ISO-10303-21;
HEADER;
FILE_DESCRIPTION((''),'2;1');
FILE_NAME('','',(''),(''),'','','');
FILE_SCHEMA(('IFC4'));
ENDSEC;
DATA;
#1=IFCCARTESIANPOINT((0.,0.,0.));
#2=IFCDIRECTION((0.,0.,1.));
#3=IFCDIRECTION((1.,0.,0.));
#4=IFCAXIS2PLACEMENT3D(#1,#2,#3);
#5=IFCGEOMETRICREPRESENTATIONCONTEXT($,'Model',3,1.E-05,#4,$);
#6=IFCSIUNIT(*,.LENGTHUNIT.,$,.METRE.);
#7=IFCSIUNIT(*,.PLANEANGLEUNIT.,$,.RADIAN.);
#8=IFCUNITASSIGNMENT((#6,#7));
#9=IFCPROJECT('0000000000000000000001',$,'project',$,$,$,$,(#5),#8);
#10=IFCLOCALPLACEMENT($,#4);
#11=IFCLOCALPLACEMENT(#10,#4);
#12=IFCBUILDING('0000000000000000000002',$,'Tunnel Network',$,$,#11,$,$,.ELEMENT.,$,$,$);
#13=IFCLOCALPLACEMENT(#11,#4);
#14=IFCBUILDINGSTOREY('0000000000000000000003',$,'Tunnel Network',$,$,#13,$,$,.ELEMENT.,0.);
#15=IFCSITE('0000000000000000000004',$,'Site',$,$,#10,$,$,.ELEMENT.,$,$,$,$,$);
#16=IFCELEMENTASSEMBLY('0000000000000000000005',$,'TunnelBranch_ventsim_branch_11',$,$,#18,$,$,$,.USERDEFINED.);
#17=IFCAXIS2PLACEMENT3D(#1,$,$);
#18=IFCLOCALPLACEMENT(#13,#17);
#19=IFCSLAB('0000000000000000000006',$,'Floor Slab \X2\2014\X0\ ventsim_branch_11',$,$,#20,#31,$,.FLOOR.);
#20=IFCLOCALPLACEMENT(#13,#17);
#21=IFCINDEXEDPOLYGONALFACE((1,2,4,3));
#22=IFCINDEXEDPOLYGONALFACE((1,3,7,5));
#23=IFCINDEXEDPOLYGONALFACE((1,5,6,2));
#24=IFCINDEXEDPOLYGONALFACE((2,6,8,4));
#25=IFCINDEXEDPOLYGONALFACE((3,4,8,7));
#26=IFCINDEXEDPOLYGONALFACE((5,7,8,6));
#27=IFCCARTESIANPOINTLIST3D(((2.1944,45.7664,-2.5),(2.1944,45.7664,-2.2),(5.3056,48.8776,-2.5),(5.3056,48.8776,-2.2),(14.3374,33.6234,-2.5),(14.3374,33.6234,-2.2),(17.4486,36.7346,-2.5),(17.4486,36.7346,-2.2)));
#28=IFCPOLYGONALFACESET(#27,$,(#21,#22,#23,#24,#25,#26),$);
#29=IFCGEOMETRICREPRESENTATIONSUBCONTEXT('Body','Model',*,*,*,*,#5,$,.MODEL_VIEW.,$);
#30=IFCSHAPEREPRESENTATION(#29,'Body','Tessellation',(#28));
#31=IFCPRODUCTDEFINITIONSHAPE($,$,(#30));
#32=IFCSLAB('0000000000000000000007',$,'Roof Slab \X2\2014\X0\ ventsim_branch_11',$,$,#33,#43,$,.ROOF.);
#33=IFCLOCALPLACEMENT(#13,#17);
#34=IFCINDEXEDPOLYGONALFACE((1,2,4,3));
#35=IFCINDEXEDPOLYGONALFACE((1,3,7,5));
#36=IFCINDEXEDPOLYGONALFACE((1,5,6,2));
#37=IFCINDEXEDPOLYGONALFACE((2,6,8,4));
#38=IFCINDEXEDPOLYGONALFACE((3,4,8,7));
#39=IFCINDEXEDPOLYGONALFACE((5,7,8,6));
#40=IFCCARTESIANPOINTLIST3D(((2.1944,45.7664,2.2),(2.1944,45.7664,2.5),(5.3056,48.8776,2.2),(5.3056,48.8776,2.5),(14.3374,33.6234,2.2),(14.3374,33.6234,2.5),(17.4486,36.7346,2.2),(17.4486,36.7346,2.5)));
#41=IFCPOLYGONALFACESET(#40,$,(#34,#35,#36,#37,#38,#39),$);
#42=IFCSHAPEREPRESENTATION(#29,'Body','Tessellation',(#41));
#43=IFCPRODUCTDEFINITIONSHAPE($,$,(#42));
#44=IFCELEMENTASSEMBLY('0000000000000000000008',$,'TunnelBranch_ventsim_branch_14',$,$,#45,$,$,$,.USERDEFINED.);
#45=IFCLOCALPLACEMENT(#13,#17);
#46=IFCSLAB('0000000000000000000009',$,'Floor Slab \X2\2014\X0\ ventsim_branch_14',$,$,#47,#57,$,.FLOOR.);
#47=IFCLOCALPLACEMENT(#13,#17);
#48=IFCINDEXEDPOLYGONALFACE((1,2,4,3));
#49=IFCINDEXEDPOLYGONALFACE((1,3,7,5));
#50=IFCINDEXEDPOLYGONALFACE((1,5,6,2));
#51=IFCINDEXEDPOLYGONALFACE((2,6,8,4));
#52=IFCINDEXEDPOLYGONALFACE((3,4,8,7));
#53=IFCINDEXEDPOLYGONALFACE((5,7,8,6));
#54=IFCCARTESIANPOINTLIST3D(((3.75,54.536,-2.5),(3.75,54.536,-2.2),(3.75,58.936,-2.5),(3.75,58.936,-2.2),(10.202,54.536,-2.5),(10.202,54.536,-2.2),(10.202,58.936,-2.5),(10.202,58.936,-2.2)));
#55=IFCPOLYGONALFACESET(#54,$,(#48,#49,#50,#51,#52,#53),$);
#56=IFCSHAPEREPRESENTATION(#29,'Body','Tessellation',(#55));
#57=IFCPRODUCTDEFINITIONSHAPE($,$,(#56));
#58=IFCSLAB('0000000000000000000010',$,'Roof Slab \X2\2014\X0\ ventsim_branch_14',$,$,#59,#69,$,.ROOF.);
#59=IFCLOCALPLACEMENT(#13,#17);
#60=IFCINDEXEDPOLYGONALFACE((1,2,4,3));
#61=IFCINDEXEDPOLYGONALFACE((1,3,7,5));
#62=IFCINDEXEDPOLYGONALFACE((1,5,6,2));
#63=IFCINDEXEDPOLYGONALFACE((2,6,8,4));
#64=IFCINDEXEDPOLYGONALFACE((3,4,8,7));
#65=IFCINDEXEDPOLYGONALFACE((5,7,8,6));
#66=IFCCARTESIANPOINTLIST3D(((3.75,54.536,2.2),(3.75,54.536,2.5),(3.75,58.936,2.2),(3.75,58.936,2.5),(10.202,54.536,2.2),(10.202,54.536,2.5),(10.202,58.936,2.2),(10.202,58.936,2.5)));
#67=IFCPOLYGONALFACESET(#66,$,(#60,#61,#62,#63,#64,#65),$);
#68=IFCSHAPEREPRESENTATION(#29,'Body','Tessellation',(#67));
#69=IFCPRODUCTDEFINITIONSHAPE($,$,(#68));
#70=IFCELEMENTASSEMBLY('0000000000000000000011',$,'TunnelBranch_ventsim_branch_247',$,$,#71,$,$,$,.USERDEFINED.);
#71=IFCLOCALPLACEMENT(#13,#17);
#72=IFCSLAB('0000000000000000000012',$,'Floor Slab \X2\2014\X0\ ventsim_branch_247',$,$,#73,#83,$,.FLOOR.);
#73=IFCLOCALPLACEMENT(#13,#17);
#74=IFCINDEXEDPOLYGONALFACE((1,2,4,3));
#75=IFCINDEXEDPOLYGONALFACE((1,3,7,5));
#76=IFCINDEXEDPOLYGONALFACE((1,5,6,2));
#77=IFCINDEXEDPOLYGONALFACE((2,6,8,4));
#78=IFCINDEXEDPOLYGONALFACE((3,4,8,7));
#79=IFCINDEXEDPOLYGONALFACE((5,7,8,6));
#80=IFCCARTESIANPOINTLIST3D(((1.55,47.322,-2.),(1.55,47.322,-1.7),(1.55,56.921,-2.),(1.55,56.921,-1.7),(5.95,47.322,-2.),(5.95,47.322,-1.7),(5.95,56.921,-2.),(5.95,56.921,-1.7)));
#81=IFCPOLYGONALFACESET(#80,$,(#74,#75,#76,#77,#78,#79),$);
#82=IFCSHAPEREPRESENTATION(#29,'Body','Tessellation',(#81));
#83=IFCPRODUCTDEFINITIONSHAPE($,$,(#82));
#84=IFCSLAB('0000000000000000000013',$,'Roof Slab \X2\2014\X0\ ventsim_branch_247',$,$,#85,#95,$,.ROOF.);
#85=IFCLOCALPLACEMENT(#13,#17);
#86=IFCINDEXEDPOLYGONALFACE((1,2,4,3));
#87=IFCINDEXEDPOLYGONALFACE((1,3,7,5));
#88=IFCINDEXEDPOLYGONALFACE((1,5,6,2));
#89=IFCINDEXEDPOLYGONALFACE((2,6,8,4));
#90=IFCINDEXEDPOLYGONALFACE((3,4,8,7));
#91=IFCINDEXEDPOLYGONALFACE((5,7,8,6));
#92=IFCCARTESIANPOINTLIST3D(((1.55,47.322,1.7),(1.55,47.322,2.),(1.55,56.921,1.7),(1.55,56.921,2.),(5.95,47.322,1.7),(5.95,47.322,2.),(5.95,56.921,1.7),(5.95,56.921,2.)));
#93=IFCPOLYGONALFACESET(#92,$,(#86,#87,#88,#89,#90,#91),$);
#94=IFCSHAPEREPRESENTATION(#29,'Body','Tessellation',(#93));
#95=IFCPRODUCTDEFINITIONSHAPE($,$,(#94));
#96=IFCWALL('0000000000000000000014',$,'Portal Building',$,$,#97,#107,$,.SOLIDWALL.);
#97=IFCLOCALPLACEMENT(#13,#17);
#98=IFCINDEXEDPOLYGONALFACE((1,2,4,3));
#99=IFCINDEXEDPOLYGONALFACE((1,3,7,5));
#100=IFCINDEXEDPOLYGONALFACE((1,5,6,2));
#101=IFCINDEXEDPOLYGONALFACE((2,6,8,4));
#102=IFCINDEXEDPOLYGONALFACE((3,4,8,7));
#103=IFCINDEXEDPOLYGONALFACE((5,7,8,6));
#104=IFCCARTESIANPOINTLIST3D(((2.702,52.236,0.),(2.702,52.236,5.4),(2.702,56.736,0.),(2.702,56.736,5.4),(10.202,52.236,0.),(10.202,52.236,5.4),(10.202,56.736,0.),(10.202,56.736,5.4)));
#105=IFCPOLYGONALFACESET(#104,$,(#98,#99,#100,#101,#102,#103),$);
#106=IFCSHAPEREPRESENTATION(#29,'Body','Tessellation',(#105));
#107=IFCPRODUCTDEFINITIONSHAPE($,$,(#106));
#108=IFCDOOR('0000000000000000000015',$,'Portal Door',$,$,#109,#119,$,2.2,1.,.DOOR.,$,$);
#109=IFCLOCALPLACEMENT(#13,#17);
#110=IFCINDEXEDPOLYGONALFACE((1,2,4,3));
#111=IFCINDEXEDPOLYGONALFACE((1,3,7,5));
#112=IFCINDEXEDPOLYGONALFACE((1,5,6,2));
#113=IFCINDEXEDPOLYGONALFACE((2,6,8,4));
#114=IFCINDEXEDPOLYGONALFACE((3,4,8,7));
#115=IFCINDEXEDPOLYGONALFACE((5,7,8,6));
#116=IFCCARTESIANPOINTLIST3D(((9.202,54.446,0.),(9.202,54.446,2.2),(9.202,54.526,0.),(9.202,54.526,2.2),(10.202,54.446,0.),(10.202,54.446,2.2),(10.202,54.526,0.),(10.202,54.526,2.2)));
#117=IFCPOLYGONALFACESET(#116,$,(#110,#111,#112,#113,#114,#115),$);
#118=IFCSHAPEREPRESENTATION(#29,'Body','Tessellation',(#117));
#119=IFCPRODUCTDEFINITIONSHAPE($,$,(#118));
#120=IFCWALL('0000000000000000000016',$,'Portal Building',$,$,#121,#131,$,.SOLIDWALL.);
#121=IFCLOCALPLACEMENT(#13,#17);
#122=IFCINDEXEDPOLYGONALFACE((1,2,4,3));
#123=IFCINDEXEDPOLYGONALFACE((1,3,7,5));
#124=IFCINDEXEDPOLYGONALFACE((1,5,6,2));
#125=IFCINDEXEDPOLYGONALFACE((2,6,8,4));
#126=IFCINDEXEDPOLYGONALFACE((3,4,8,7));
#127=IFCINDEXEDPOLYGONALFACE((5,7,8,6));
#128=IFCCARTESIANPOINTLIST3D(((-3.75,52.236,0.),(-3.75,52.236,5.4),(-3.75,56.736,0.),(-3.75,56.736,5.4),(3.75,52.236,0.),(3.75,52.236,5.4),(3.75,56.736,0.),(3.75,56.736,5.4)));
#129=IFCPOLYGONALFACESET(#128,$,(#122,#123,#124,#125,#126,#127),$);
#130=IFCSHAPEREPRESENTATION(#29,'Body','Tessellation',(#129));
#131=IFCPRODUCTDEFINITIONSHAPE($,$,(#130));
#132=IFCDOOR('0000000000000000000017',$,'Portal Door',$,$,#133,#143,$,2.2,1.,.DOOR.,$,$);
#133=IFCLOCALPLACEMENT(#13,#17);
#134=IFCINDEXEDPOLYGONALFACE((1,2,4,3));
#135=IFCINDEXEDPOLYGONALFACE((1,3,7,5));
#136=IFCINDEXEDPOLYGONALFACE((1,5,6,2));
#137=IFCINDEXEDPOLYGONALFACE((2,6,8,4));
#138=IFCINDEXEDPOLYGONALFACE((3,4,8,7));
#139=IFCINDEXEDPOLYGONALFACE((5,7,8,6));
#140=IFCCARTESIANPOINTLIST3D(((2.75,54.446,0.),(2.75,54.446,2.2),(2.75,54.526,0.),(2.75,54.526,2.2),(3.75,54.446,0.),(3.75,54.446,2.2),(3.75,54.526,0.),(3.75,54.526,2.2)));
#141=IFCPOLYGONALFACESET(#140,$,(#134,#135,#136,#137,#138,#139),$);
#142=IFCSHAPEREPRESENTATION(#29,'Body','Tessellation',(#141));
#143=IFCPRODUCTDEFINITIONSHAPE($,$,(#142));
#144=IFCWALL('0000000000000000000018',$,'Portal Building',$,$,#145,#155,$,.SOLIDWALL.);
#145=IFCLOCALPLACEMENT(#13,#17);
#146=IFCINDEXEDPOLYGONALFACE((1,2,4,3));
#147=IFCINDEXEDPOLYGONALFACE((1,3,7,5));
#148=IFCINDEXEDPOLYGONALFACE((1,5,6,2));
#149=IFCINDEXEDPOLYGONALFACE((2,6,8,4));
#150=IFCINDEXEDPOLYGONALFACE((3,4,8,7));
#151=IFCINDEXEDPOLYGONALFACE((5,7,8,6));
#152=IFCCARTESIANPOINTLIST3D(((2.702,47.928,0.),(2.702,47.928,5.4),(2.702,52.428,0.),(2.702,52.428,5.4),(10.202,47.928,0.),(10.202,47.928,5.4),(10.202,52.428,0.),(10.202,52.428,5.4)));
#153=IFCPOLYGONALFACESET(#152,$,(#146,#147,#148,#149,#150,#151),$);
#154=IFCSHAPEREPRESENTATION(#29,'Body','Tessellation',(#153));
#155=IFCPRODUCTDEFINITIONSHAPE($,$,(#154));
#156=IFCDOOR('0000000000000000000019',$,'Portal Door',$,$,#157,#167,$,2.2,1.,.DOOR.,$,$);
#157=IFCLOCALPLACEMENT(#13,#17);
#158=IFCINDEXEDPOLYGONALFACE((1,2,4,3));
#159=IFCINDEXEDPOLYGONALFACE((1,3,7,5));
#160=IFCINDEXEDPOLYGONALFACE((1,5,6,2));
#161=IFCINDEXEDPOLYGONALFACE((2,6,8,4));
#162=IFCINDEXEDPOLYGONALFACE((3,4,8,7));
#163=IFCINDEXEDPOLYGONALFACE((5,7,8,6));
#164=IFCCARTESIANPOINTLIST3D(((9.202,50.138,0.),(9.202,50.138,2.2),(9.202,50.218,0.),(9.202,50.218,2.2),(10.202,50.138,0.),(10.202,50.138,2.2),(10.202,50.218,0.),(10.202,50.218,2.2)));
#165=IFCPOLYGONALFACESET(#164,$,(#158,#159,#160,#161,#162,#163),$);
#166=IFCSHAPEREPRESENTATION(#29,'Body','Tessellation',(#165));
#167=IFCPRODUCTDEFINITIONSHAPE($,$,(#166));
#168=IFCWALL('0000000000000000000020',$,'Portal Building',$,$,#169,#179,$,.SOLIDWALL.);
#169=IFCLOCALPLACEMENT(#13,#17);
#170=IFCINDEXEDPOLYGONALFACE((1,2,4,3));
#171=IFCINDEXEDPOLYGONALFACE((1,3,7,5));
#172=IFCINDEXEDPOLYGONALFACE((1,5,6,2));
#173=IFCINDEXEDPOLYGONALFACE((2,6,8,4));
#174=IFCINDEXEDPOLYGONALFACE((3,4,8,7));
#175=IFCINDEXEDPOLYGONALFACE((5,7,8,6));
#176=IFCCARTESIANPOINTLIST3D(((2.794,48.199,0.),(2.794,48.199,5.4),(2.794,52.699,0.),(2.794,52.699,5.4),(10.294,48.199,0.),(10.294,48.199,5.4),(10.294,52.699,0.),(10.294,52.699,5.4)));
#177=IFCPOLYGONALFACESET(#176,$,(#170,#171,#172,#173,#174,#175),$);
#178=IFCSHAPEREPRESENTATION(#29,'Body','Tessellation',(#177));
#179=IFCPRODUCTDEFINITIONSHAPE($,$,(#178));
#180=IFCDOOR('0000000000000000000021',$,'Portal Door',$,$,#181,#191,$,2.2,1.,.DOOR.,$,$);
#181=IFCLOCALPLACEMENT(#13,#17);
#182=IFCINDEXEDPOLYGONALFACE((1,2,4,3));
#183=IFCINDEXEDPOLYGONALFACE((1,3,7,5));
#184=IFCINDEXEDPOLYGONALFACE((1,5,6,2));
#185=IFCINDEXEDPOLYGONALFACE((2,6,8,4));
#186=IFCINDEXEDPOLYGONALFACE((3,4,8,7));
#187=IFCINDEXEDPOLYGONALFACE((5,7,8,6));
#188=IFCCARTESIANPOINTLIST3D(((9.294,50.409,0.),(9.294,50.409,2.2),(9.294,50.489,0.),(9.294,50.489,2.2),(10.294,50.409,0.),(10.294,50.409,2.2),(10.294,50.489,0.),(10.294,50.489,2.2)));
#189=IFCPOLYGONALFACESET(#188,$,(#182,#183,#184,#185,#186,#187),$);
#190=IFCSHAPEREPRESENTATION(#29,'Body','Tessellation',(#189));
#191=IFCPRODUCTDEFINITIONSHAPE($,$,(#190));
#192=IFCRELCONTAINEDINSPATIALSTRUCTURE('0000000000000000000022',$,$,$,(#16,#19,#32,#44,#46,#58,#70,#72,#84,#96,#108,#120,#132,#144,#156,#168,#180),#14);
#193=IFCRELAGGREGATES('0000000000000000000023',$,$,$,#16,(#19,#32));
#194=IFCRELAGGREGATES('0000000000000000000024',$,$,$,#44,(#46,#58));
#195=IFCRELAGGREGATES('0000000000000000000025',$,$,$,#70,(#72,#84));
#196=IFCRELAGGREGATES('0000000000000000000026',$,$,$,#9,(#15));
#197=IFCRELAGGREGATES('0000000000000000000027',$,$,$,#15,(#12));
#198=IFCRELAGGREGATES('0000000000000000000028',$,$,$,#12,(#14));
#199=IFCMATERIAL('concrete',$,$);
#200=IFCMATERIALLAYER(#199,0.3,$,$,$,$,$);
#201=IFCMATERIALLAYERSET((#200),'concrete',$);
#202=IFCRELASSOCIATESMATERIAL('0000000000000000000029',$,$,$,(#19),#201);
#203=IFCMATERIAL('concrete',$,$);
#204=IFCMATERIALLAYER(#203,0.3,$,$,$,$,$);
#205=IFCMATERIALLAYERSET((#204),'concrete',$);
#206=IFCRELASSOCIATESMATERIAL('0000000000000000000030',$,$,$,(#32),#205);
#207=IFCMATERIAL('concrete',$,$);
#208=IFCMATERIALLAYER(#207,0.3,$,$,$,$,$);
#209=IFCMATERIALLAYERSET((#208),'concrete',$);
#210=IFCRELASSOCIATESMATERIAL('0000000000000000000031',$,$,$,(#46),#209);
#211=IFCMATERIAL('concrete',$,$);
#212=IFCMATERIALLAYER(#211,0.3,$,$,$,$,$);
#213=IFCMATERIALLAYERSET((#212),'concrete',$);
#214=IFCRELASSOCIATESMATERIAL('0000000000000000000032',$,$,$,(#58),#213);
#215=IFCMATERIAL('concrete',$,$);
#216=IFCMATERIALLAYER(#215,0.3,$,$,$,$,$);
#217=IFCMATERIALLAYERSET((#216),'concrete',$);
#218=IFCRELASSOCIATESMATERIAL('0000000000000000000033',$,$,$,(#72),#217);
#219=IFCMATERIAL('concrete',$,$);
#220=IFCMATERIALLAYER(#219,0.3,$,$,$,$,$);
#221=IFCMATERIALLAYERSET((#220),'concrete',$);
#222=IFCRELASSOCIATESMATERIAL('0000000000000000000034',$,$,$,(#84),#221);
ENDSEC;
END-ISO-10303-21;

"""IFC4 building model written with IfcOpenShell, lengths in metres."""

from ifc_helpers import new_model, si_unit, frame, origin_with_axes, origin_2d_with_axis, place, context, subcontext, project, spatial, rectangle, extrude, material, layer, layer_set, layer_usage, element, aggregate, save


model = new_model("IFC4")

# Units and contexts
model_context = context("Model", 3, precision=1e-05, world=origin_with_axes())
body_context = subcontext(model_context, "Body", "Model", "MODEL_VIEW")
ifc_project = project(units=[si_unit("LENGTHUNIT", "METRE"), si_unit("PLANEANGLEUNIT", "RADIAN")], contexts=[model_context])

# Site, building, storey
site_placement = place(None, origin_with_axes())
site = spatial("IfcSite", under=ifc_project, at=site_placement, Name="Site", CompositionType="ELEMENT")
building_placement = place(site_placement, origin_with_axes())
building = spatial("IfcBuilding", under=site, at=building_placement, Name="Tunnel Network", CompositionType="ELEMENT")
storey_placement = place(building_placement, origin_with_axes())
storey = spatial("IfcBuildingStorey", under=building, at=storey_placement, Name="Tunnel Network", CompositionType="ELEMENT", Elevation=0.0)

# Element assemblies, slabs
assembly_1_placement = place(storey_placement, frame((5.4117, 48.9837, 0.0), z_axis=(0.707107, -0.707107, 0.0), x_axis=(-0.707107, -0.707107, 0.0)))
assembly_1 = element("IfcElementAssembly", 1, at=assembly_1_placement, inside=storey, Name="TunnelBranch_ventsim_branch_11", PredefinedType="USERDEFINED")
ifc_material_1 = material(Name="concrete")
ifc_layer_1 = layer(ifc_material_1, 0.3)
ifc_layer_set_1 = layer_set([ifc_layer_1], Name="concrete")
ifc_layer_usage_1 = layer_usage(ifc_layer_set_1, "AXIS3", "POSITIVE", 0.0)
slab_1_placement = place(storey_placement, frame((3.75, 47.322, -2.35), z_axis=(0.707107, -0.707107, 0.0), x_axis=(-0.707107, -0.707107, 0.0)))
slab_1 = element("IfcSlab", 2, at=slab_1_placement, inside=storey, material=ifc_layer_usage_1, Name="Floor Slab — ventsim_branch_11", PredefinedType="FLOOR", context=body_context, shape_type="SweptSolid", body=[
    extrude(rectangle(XDim=4.4, YDim=0.3, at=origin_2d_with_axis()), origin_with_axes(), (0.0, 0.0, 1.0), 17.1728),
])
ifc_material_2 = material(Name="concrete")
ifc_layer_2 = layer(ifc_material_2, 0.3)
ifc_layer_set_2 = layer_set([ifc_layer_2], Name="concrete")
ifc_layer_usage_2 = layer_usage(ifc_layer_set_2, "AXIS3", "POSITIVE", 0.0)
slab_2_placement = place(storey_placement, frame((3.75, 47.322, 2.35), z_axis=(0.707107, -0.707107, 0.0), x_axis=(-0.707107, -0.707107, 0.0)))
slab_2 = element("IfcSlab", 3, at=slab_2_placement, inside=storey, material=ifc_layer_usage_2, Name="Roof Slab — ventsim_branch_11", PredefinedType="ROOF", context=body_context, shape_type="SweptSolid", body=[
    extrude(rectangle(XDim=4.4, YDim=0.3, at=origin_2d_with_axis()), origin_with_axes(), (0.0, 0.0, 1.0), 17.1728),
])
assembly_2_placement = place(storey_placement, frame((10.202, 54.386, 0.0), z_axis=(-1.0, 0.0, 0.0), x_axis=(0.0, 1.0, 0.0)))
assembly_2 = element("IfcElementAssembly", 4, at=assembly_2_placement, inside=storey, Name="TunnelBranch_ventsim_branch_14", PredefinedType="USERDEFINED")
ifc_material_3 = material(Name="concrete")
ifc_layer_3 = layer(ifc_material_3, 0.3)
ifc_layer_set_3 = layer_set([ifc_layer_3], Name="concrete")
ifc_layer_usage_3 = layer_usage(ifc_layer_set_3, "AXIS3", "POSITIVE", 0.0)
slab_3_placement = place(storey_placement, frame((10.202, 56.736, -2.35), z_axis=(-1.0, 0.0, 0.0), x_axis=(0.0, 1.0, 0.0)))
slab_3 = element("IfcSlab", 5, at=slab_3_placement, inside=storey, material=ifc_layer_usage_3, Name="Floor Slab — ventsim_branch_14", PredefinedType="FLOOR", context=body_context, shape_type="SweptSolid", body=[
    extrude(rectangle(XDim=4.4, YDim=0.3, at=origin_2d_with_axis()), origin_with_axes(), (0.0, 0.0, 1.0), 6.452),
])
ifc_material_4 = material(Name="concrete")
ifc_layer_4 = layer(ifc_material_4, 0.3)
ifc_layer_set_4 = layer_set([ifc_layer_4], Name="concrete")
ifc_layer_usage_4 = layer_usage(ifc_layer_set_4, "AXIS3", "POSITIVE", 0.0)
slab_4_placement = place(storey_placement, frame((10.202, 56.736, 2.35), z_axis=(-1.0, 0.0, 0.0), x_axis=(0.0, 1.0, 0.0)))
slab_4 = element("IfcSlab", 6, at=slab_4_placement, inside=storey, material=ifc_layer_usage_4, Name="Roof Slab — ventsim_branch_14", PredefinedType="ROOF", context=body_context, shape_type="SweptSolid", body=[
    extrude(rectangle(XDim=4.4, YDim=0.3, at=origin_2d_with_axis()), origin_with_axes(), (0.0, 0.0, 1.0), 6.452),
])
assembly_3_placement = place(storey_placement, frame((1.4, 47.322, 0.0), z_axis=(0.0, 1.0, 0.0), x_axis=(1.0, 0.0, 0.0)))
assembly_3 = element("IfcElementAssembly", 7, at=assembly_3_placement, inside=storey, Name="TunnelBranch_ventsim_branch_247", PredefinedType="USERDEFINED")
ifc_material_5 = material(Name="concrete")
ifc_layer_5 = layer(ifc_material_5, 0.3)
ifc_layer_set_5 = layer_set([ifc_layer_5], Name="concrete")
ifc_layer_usage_5 = layer_usage(ifc_layer_set_5, "AXIS3", "POSITIVE", 0.0)
slab_5_placement = place(storey_placement, frame((3.75, 47.322, -1.85), z_axis=(0.0, 1.0, 0.0), x_axis=(1.0, 0.0, 0.0)))
slab_5 = element("IfcSlab", 8, at=slab_5_placement, inside=storey, material=ifc_layer_usage_5, Name="Floor Slab — ventsim_branch_247", PredefinedType="FLOOR", context=body_context, shape_type="SweptSolid", body=[
    extrude(rectangle(XDim=4.4, YDim=0.3, at=origin_2d_with_axis()), origin_with_axes(), (0.0, 0.0, 1.0), 9.599),
])
ifc_material_6 = material(Name="concrete")
ifc_layer_6 = layer(ifc_material_6, 0.3)
ifc_layer_set_6 = layer_set([ifc_layer_6], Name="concrete")
ifc_layer_usage_6 = layer_usage(ifc_layer_set_6, "AXIS3", "POSITIVE", 0.0)
slab_6_placement = place(storey_placement, frame((3.75, 47.322, 1.85), z_axis=(0.0, 1.0, 0.0), x_axis=(1.0, 0.0, 0.0)))
slab_6 = element("IfcSlab", 9, at=slab_6_placement, inside=storey, material=ifc_layer_usage_6, Name="Roof Slab — ventsim_branch_247", PredefinedType="ROOF", context=body_context, shape_type="SweptSolid", body=[
    extrude(rectangle(XDim=4.4, YDim=0.3, at=origin_2d_with_axis()), origin_with_axes(), (0.0, 0.0, 1.0), 9.599),
])

# Wall
wall_1_placement = place(storey_placement, frame((6.452, 54.486, 0.0), z_axis=(0.0, 0.0, 1.0), x_axis=(1.0, 0.0, 0.0)))
element("IfcWall", 10, at=wall_1_placement, inside=storey, Name="Portal Building", PredefinedType="SOLIDWALL", context=body_context, shape_type="SweptSolid", body=[
    extrude(rectangle(XDim=7.5, YDim=4.5, at=origin_2d_with_axis()), origin_with_axes(), (0.0, 0.0, 1.0), 5.4),
])

# Door
door_1_placement = place(storey_placement, frame((9.702, 54.486, 0.0), z_axis=(0.0, 0.0, 1.0), x_axis=(1.0, 0.0, 0.0)))
element("IfcDoor", 11, at=door_1_placement, inside=storey, Name="Portal Door", OverallHeight=2.2, OverallWidth=1.0, PredefinedType="DOOR", context=body_context, shape_type="SweptSolid", body=[
    extrude(rectangle(XDim=1.0, YDim=0.08, at=origin_2d_with_axis()), origin_with_axes(), (0.0, 0.0, 1.0), 2.2),
])

# Wall
wall_2_placement = place(storey_placement, frame((0.0, 54.486, 0.0), z_axis=(0.0, 0.0, 1.0), x_axis=(1.0, 0.0, 0.0)))
element("IfcWall", 12, at=wall_2_placement, inside=storey, Name="Portal Building", PredefinedType="SOLIDWALL", context=body_context, shape_type="SweptSolid", body=[
    extrude(rectangle(XDim=7.5, YDim=4.5, at=origin_2d_with_axis()), origin_with_axes(), (0.0, 0.0, 1.0), 5.4),
])

# Door
door_2_placement = place(storey_placement, frame((3.25, 54.486, 0.0), z_axis=(0.0, 0.0, 1.0), x_axis=(1.0, 0.0, 0.0)))
element("IfcDoor", 13, at=door_2_placement, inside=storey, Name="Portal Door", OverallHeight=2.2, OverallWidth=1.0, PredefinedType="DOOR", context=body_context, shape_type="SweptSolid", body=[
    extrude(rectangle(XDim=1.0, YDim=0.08, at=origin_2d_with_axis()), origin_with_axes(), (0.0, 0.0, 1.0), 2.2),
])

# Wall
wall_3_placement = place(storey_placement, frame((6.452, 50.178, 0.0), z_axis=(0.0, 0.0, 1.0), x_axis=(1.0, 0.0, 0.0)))
element("IfcWall", 14, at=wall_3_placement, inside=storey, Name="Portal Building", PredefinedType="SOLIDWALL", context=body_context, shape_type="SweptSolid", body=[
    extrude(rectangle(XDim=7.5, YDim=4.5, at=origin_2d_with_axis()), origin_with_axes(), (0.0, 0.0, 1.0), 5.4),
])

# Door
door_3_placement = place(storey_placement, frame((9.702, 50.178, 0.0), z_axis=(0.0, 0.0, 1.0), x_axis=(1.0, 0.0, 0.0)))
element("IfcDoor", 15, at=door_3_placement, inside=storey, Name="Portal Door", OverallHeight=2.2, OverallWidth=1.0, PredefinedType="DOOR", context=body_context, shape_type="SweptSolid", body=[
    extrude(rectangle(XDim=1.0, YDim=0.08, at=origin_2d_with_axis()), origin_with_axes(), (0.0, 0.0, 1.0), 2.2),
])

# Wall
wall_4_placement = place(storey_placement, frame((6.544, 50.449, 0.0), z_axis=(0.0, 0.0, 1.0), x_axis=(1.0, 0.0, 0.0)))
element("IfcWall", 16, at=wall_4_placement, inside=storey, Name="Portal Building", PredefinedType="SOLIDWALL", context=body_context, shape_type="SweptSolid", body=[
    extrude(rectangle(XDim=7.5, YDim=4.5, at=origin_2d_with_axis()), origin_with_axes(), (0.0, 0.0, 1.0), 5.4),
])

# Door
door_4_placement = place(storey_placement, frame((9.794, 50.449, 0.0), z_axis=(0.0, 0.0, 1.0), x_axis=(1.0, 0.0, 0.0)))
element("IfcDoor", 17, at=door_4_placement, inside=storey, Name="Portal Door", OverallHeight=2.2, OverallWidth=1.0, PredefinedType="DOOR", context=body_context, shape_type="SweptSolid", body=[
    extrude(rectangle(XDim=1.0, YDim=0.08, at=origin_2d_with_axis()), origin_with_axes(), (0.0, 0.0, 1.0), 2.2),
])

aggregate(assembly_1, [slab_1, slab_2])

aggregate(assembly_2, [slab_3, slab_4])

aggregate(assembly_3, [slab_5, slab_6])

save(model, "model.ifc")
